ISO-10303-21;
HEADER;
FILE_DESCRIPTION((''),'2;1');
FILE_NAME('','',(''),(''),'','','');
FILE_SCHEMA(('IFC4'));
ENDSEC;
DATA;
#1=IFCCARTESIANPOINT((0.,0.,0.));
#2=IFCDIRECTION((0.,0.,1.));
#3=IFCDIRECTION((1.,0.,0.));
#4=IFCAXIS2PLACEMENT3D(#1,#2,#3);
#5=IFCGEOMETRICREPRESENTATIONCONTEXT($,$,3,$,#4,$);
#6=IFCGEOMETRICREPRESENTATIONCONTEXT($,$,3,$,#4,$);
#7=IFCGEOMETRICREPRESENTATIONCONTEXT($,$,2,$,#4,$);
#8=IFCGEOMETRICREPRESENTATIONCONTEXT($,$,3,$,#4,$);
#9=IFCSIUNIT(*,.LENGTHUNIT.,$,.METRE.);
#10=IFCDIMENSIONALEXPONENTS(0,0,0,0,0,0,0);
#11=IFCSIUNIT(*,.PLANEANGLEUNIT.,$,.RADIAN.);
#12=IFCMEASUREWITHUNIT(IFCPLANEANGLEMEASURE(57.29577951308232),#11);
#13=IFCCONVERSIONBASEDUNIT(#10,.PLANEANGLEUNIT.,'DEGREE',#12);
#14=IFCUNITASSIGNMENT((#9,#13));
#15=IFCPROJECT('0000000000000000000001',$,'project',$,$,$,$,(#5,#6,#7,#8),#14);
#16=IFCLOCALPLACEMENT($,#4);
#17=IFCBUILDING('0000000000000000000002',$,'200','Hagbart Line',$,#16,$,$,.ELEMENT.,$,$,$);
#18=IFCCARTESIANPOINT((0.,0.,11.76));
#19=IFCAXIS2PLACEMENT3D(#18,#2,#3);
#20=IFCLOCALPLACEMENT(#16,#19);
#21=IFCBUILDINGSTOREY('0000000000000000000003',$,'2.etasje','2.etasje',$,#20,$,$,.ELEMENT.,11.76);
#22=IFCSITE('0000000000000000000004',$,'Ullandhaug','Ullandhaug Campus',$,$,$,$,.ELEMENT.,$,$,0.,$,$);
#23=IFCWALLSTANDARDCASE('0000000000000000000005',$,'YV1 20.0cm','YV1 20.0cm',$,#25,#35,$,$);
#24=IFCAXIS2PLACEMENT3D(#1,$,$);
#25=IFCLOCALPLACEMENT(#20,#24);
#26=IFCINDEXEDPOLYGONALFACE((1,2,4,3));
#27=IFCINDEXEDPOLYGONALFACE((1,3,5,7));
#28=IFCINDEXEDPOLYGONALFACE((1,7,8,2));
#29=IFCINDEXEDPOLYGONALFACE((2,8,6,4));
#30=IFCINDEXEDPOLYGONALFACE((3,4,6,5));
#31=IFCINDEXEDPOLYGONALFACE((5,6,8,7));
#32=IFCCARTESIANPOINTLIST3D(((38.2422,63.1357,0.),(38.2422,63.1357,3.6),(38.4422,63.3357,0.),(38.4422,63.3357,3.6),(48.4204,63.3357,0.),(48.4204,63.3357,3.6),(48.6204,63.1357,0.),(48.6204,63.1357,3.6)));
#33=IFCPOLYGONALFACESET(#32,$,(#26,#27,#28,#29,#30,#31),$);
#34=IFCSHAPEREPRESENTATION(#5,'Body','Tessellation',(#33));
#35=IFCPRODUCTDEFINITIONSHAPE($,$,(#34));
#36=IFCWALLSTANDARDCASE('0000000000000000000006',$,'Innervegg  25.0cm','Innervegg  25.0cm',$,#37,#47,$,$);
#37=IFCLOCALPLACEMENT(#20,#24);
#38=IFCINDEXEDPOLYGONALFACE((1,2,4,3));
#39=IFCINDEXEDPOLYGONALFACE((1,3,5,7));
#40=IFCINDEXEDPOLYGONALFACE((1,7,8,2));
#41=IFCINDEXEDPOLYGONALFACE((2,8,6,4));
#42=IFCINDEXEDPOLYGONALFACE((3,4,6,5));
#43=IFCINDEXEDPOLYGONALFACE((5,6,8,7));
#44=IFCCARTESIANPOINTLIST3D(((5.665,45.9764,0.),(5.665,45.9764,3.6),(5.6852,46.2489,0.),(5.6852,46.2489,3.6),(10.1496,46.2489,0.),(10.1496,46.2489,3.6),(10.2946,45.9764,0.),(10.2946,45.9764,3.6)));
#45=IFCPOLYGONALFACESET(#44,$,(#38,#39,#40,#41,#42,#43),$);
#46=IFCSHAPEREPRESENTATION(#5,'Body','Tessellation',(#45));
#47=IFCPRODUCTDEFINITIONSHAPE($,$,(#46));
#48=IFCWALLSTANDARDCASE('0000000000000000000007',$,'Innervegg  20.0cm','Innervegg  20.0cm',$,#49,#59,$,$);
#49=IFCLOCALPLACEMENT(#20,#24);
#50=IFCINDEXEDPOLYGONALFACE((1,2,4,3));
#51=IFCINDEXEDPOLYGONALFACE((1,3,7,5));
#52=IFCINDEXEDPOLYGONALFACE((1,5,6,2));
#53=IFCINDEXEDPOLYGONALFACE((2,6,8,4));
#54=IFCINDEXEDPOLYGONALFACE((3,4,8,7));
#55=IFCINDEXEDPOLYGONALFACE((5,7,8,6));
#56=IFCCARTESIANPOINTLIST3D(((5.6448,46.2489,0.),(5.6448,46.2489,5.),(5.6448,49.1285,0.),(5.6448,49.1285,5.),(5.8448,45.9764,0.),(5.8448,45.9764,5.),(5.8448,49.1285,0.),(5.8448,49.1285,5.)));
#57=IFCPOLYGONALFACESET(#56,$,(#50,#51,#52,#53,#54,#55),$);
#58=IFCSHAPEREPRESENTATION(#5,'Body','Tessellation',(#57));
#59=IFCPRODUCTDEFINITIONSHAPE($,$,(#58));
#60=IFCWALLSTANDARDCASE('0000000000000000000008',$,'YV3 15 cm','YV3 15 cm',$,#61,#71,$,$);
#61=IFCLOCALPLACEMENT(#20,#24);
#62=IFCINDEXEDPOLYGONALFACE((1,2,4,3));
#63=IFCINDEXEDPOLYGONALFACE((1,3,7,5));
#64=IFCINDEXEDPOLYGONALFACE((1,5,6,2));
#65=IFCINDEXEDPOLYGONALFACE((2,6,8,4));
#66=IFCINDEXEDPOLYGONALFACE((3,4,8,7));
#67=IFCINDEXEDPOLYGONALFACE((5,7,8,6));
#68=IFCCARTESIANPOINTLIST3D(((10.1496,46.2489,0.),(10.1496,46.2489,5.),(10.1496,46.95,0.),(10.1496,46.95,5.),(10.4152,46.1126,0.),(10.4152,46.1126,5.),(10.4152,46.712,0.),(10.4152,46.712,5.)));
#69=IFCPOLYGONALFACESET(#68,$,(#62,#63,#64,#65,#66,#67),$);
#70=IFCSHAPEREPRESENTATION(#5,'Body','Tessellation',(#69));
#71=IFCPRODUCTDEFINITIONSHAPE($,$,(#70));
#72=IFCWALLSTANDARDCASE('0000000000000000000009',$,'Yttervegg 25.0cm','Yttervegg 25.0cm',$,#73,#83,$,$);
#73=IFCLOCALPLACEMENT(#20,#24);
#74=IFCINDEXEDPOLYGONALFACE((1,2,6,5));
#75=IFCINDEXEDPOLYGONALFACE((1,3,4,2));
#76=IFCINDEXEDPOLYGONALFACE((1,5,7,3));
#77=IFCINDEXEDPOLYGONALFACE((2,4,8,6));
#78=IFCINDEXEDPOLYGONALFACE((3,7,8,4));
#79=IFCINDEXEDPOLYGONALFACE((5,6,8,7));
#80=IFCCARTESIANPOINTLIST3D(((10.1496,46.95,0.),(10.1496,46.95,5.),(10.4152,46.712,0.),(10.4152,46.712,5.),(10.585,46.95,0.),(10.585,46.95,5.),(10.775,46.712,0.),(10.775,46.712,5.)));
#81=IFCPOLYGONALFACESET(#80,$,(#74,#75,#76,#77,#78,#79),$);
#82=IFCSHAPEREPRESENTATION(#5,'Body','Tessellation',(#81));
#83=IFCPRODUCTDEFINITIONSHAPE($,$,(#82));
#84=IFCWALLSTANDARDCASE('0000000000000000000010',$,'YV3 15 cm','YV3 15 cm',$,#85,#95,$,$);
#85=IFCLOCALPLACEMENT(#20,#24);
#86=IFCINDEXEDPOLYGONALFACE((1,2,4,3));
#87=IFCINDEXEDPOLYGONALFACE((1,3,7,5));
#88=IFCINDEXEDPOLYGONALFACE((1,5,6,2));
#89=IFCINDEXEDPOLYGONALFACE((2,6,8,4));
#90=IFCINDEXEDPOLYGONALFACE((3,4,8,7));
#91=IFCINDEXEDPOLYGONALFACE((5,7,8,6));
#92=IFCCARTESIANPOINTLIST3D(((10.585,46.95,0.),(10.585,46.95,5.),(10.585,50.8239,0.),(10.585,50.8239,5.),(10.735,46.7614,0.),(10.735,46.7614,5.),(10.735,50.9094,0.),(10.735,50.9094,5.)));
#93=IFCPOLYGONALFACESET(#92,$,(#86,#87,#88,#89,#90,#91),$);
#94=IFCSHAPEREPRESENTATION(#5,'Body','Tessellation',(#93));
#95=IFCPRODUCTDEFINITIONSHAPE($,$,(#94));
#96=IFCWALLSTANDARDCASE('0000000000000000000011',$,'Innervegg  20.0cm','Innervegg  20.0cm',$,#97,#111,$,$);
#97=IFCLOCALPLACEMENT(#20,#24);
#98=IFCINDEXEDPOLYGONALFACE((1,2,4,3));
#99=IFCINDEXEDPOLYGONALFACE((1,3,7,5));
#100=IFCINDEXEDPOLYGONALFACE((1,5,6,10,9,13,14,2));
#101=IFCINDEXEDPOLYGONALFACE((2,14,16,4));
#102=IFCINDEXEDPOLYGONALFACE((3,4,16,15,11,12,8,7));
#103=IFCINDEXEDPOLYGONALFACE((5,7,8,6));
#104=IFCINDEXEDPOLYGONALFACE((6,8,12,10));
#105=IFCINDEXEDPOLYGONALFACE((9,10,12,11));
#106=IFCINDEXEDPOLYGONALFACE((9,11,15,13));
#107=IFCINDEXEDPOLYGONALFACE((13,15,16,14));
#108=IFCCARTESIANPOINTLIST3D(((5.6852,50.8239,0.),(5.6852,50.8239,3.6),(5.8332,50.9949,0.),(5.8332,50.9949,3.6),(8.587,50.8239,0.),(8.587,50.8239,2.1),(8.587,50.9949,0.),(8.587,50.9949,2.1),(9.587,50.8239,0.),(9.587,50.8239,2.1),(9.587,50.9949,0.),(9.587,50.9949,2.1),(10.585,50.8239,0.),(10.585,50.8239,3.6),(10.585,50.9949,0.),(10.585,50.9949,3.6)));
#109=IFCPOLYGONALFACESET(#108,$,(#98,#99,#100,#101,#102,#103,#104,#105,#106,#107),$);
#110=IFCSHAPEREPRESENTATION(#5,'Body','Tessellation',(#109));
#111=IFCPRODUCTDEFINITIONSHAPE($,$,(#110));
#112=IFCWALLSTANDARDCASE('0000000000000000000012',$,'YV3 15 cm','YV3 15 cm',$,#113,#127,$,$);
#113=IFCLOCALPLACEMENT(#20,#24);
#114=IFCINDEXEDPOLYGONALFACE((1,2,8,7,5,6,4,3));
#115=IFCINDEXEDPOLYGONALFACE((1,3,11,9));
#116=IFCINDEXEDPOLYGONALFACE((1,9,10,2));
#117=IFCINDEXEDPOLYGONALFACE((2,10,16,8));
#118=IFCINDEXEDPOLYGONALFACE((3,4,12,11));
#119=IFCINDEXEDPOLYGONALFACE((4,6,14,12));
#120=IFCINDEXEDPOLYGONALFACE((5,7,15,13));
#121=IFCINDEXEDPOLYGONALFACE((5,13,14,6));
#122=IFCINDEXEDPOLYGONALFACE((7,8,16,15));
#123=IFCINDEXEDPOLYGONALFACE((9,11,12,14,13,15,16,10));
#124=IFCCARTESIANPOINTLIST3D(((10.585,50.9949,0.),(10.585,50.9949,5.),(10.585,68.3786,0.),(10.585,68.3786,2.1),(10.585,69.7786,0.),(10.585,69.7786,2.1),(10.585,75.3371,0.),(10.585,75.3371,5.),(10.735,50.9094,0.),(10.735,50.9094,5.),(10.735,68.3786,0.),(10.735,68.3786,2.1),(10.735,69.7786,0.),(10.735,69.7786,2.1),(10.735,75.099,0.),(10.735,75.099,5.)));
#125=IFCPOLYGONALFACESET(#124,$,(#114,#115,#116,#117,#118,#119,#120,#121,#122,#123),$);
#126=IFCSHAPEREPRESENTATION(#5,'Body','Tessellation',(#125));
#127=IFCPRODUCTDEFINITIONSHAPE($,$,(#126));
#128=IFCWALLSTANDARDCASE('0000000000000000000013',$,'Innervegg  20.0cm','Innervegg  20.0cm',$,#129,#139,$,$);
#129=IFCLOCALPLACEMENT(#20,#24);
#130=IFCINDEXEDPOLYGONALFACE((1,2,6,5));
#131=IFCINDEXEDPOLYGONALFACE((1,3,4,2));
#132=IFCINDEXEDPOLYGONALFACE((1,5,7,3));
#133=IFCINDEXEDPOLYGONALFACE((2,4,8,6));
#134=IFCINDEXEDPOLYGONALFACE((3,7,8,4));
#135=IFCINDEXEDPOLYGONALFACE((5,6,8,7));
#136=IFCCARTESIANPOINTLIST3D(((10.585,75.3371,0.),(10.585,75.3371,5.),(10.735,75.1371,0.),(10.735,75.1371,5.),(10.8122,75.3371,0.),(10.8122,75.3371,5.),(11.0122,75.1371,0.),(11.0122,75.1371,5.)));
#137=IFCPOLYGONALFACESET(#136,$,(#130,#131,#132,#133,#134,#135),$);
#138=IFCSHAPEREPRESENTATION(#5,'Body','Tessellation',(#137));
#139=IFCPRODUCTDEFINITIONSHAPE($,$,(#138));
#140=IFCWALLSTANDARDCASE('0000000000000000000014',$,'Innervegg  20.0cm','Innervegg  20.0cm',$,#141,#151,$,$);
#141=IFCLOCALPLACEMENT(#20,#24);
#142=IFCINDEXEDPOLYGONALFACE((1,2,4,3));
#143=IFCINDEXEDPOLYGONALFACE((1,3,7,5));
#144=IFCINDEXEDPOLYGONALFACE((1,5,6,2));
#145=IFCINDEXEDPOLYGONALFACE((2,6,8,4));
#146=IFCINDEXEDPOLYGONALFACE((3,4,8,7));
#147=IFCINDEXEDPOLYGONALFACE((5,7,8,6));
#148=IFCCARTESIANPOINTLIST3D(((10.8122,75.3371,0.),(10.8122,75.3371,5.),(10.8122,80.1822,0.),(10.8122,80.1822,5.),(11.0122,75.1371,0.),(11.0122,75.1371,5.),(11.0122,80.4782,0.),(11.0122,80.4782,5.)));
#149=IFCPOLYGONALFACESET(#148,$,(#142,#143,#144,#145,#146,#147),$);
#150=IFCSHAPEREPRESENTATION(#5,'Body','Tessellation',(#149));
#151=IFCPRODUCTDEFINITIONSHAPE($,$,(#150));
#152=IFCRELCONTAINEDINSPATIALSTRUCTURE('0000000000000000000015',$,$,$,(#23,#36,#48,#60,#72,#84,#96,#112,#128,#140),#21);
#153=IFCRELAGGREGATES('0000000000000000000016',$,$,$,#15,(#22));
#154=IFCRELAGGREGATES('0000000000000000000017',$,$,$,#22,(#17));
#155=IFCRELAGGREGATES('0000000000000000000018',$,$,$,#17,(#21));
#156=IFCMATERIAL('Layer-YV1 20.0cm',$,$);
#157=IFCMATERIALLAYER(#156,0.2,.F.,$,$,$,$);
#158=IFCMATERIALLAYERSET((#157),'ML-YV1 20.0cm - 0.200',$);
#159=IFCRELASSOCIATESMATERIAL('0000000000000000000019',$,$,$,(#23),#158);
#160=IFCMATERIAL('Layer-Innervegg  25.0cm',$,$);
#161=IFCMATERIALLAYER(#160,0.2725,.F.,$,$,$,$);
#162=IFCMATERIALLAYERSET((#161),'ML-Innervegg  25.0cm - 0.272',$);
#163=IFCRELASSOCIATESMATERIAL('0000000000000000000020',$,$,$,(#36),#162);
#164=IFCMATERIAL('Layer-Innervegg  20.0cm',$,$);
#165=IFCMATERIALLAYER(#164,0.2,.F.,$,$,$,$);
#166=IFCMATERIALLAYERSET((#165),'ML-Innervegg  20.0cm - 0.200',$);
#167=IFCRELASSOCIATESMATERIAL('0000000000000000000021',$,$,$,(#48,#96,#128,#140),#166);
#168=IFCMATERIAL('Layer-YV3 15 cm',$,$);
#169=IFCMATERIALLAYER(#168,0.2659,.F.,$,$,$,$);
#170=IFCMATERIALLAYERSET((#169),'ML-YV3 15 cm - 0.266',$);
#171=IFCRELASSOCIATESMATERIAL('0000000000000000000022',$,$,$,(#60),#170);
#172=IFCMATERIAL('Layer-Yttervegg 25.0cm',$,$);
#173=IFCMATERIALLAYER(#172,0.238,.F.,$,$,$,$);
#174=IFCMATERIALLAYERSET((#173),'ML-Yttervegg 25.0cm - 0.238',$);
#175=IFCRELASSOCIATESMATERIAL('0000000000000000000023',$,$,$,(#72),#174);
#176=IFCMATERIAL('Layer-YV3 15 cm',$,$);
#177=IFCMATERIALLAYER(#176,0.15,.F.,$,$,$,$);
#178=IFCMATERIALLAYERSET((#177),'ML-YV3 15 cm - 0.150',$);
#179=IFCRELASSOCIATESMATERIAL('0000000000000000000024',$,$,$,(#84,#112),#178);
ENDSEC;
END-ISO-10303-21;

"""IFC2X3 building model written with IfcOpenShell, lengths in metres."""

from ifc_helpers import new_model, entity, si_unit, converted_unit, frame, origin_with_axes, place, context, project, spatial, polyline, outline, extrude, material, layer, layer_set, layer_usage, element, save


model = new_model("IFC2X3")

# Units and contexts
context_of_model_1 = context(None, 3, world=origin_with_axes())
context_of_model_2 = context(None, 3, world=origin_with_axes())
context_of_model_3 = context(None, 2, world=origin_with_axes())
context_of_model_4 = context(None, 3, world=origin_with_axes())
ifc_project = project(units=[si_unit("LENGTHUNIT", "METRE"), converted_unit("PLANEANGLEUNIT", "DEGREE", entity("IfcPlaneAngleMeasure", 57.29577951308232), si_unit("PLANEANGLEUNIT", "RADIAN"), dimensions=[0, 0, 0, 0, 0, 0, 0])], contexts=[context_of_model_1, context_of_model_2, context_of_model_3, context_of_model_4])

# Site, building, storey
site = spatial("IfcSite", under=ifc_project, Name="Ullandhaug", Description="Ullandhaug Campus", CompositionType="ELEMENT", RefElevation=0.0)
building_placement = place(None, origin_with_axes())
building = spatial("IfcBuilding", under=site, at=building_placement, Name="200", Description="Hagbart Line", CompositionType="ELEMENT")
storey_placement = place(building_placement, frame((0.0, 0.0, 11.76), z_axis=(0.0, 0.0, 1.0), x_axis=(1.0, 0.0, 0.0)))
storey = spatial("IfcBuildingStorey", under=building, at=storey_placement, Name="2.etasje", Description="2.etasje", CompositionType="ELEMENT", Elevation=11.76)

# Walls
ifc_material_1 = material(Name="Layer-YV3 15 cm")
ifc_layer_1 = layer(ifc_material_1, 0.15, ventilated=False)
ifc_layer_set_1 = layer_set([ifc_layer_1], Name="ML-YV3 15 cm - 0.150")
ifc_layer_usage_1 = layer_usage(ifc_layer_set_1, "AXIS2", "POSITIVE", 0.0)
ifc_material_2 = material(Name="Layer-YV1 20.0cm")
ifc_layer_2 = layer(ifc_material_2, 0.2, ventilated=False)
ifc_layer_set_2 = layer_set([ifc_layer_2], Name="ML-YV1 20.0cm - 0.200")
ifc_layer_usage_2 = layer_usage(ifc_layer_set_2, "AXIS2", "POSITIVE", 0.0)
wall_1_placement = place(storey_placement, frame((48.4204, 63.3357, 0.0), z_axis=(0.0, 0.0, 1.0), x_axis=(-1.0, 0.0, 0.0)))
element("IfcWallStandardCase", 1, at=wall_1_placement, inside=storey, material=ifc_layer_usage_2, Name="YV1 20.0cm", Description="YV1 20.0cm", context=context_of_model_1, shape_type="SweptSolid", body=[
    extrude(outline(polyline([(0.0, 0.0), (9.9782, 0.0), (10.1782, 0.2), (-0.2, 0.2), (0.0, 0.0)])), frame((0.0, 0.0, 0.0), z_axis=(0.0, 0.0, 1.0), x_axis=(1.0, 0.0, 0.0)), (0.0, 0.0, 1.0), 3.6),
])
ifc_material_3 = material(Name="Layer-Innervegg  25.0cm")
ifc_layer_3 = layer(ifc_material_3, 0.2725, ventilated=False)
ifc_layer_set_3 = layer_set([ifc_layer_3], Name="ML-Innervegg  25.0cm - 0.272")
ifc_layer_usage_3 = layer_usage(ifc_layer_set_3, "AXIS2", "POSITIVE", 0.0)
wall_2_placement = place(storey_placement, frame((10.1496, 46.2489, 0.0), z_axis=(0.0, 0.0, 1.0), x_axis=(-1.0, 0.0, 0.0)))
element("IfcWallStandardCase", 2, at=wall_2_placement, inside=storey, material=ifc_layer_usage_3, Name="Innervegg  25.0cm", Description="Innervegg  25.0cm", context=context_of_model_1, shape_type="SweptSolid", body=[
    extrude(outline(polyline([(0.0, 0.0), (4.4644, 0.0), (4.4846, 0.2725), (-0.145, 0.2725), (0.0, 0.0)])), frame((0.0, 0.0, 0.0), z_axis=(0.0, 0.0, 1.0), x_axis=(1.0, 0.0, 0.0)), (0.0, 0.0, 1.0), 3.6),
])
ifc_material_4 = material(Name="Layer-Innervegg  20.0cm")
ifc_layer_4 = layer(ifc_material_4, 0.2, ventilated=False)
ifc_layer_set_4 = layer_set([ifc_layer_4], Name="ML-Innervegg  20.0cm - 0.200")
ifc_layer_usage_4 = layer_usage(ifc_layer_set_4, "AXIS2", "POSITIVE", 0.0)
wall_3_placement = place(storey_placement, frame((5.8448, 45.9764, 0.0), z_axis=(0.0, 0.0, 1.0), x_axis=(0.0, 1.0, 0.0)))
element("IfcWallStandardCase", 3, at=wall_3_placement, inside=storey, material=ifc_layer_usage_4, Name="Innervegg  20.0cm", Description="Innervegg  20.0cm", context=context_of_model_1, shape_type="SweptSolid", body=[
    extrude(outline(polyline([(0.0, 0.0), (3.1521, 0.0), (3.1521, 0.2), (0.2725, 0.2), (0.0, 0.0)])), frame((0.0, 0.0, 0.0), z_axis=(0.0, 0.0, 1.0), x_axis=(1.0, 0.0, 0.0)), (0.0, 0.0, 1.0), 5.0),
])
ifc_material_5 = material(Name="Layer-YV3 15 cm")
ifc_layer_5 = layer(ifc_material_5, 0.2659, ventilated=False)
ifc_layer_set_5 = layer_set([ifc_layer_5], Name="ML-YV3 15 cm - 0.266")
ifc_layer_usage_5 = layer_usage(ifc_layer_set_5, "AXIS2", "POSITIVE", 0.0)
wall_4_placement = place(storey_placement, frame((10.4152, 46.1126, 0.0), z_axis=(0.0, 0.0, 1.0), x_axis=(0.0, 1.0, 0.0)))
element("IfcWallStandardCase", 4, at=wall_4_placement, inside=storey, material=ifc_layer_usage_5, Name="YV3 15 cm", Description="YV3 15 cm", context=context_of_model_1, shape_type="SweptSolid", body=[
    extrude(outline(polyline([(0.0, 0.0), (0.5993, 0.0), (0.8373, 0.2656), (0.1362, 0.2656), (0.0, 0.0)])), frame((0.0, 0.0, 0.0), z_axis=(0.0, 0.0, 1.0), x_axis=(1.0, 0.0, 0.0)), (0.0, 0.0, 1.0), 5.0),
])
ifc_material_6 = material(Name="Layer-Yttervegg 25.0cm")
ifc_layer_6 = layer(ifc_material_6, 0.238, ventilated=False)
ifc_layer_set_6 = layer_set([ifc_layer_6], Name="ML-Yttervegg 25.0cm - 0.238")
ifc_layer_usage_6 = layer_usage(ifc_layer_set_6, "AXIS2", "POSITIVE", 0.0)
wall_5_placement = place(storey_placement, frame((10.4152, 46.712, 0.0), z_axis=(0.0, 0.0, 1.0), x_axis=(1.0, 0.0, 0.0)))
element("IfcWallStandardCase", 5, at=wall_5_placement, inside=storey, material=ifc_layer_usage_6, Name="Yttervegg 25.0cm", Description="Yttervegg 25.0cm", context=context_of_model_1, shape_type="SweptSolid", body=[
    extrude(outline(polyline([(0.0, 0.0), (0.3598, 0.0), (0.1698, 0.238), (-0.2656, 0.238), (0.0, 0.0)])), origin_with_axes(), (0.0, 0.0, 1.0), 5.0),
])
wall_6_placement = place(storey_placement, frame((10.735, 46.7614, 0.0), z_axis=(0.0, 0.0, 1.0), x_axis=(0.0, 1.0, 0.0)))
element("IfcWallStandardCase", 6, at=wall_6_placement, inside=storey, material=ifc_layer_usage_1, Name="YV3 15 cm", Description="YV3 15 cm", context=context_of_model_1, shape_type="SweptSolid", body=[
    extrude(outline(polyline([(0.0, 0.0), (4.148, 0.0), (4.0625, 0.15), (0.1885, 0.15), (0.0, 0.0)])), frame((0.0, 0.0, 0.0), z_axis=(0.0, 0.0, 1.0), x_axis=(1.0, 0.0, 0.0)), (0.0, 0.0, 1.0), 5.0),
])

# Wall, opening
wall_7_placement = place(storey_placement, frame((10.585, 50.9949, 0.0), z_axis=(0.0, 0.0, 1.0), x_axis=(-1.0, 0.0, 0.0)))
wall_7 = element("IfcWallStandardCase", 7, at=wall_7_placement, inside=storey, material=ifc_layer_usage_4, Name="Innervegg  20.0cm", Description="Innervegg  20.0cm", context=context_of_model_1, shape_type="SweptSolid", body=[
    extrude(outline(polyline([(0.0, 0.0), (4.7518, 0.0), (4.8998, 0.171), (0.0, 0.171), (0.0, 0.0)])), frame((0.0, 0.0, 0.0), z_axis=(0.0, 0.0, 1.0), x_axis=(1.0, 0.0, 0.0)), (0.0, 0.0, 1.0), 3.6),
])
opening_1_placement = place(wall_7_placement, frame((0.998, 0.171, 0.0), z_axis=(0.0, 0.0, 1.0), x_axis=(1.0, 0.0, 0.0)))
element("IfcOpeningElement", 8, at=opening_1_placement, cuts=wall_7, context=context_of_model_1, shape_type="SweptSolid", body=[
    extrude(outline(polyline([(0.0, 0.0), (2.1, 0.0), (2.1, 1.0), (0.0, 1.0), (0.0, 0.0)])), frame((0.0, 0.0, 0.0), z_axis=(0.0, 1.0, 0.0), x_axis=(0.0, 0.0, 1.0)), (0.0, 0.0, -1.0), 0.2),
])

# Wall, opening
wall_8_placement = place(storey_placement, frame((10.735, 50.9094, 0.0), z_axis=(0.0, 0.0, 1.0), x_axis=(0.0, 1.0, 0.0)))
wall_8 = element("IfcWallStandardCase", 9, at=wall_8_placement, inside=storey, material=ifc_layer_usage_1, Name="YV3 15 cm", Description="YV3 15 cm", context=context_of_model_1, shape_type="SweptSolid", body=[
    extrude(outline(polyline([(0.0, 0.0), (24.1897, 0.0), (24.4277, 0.15), (0.0855, 0.15), (0.0, 0.0)])), frame((0.0, 0.0, 0.0), z_axis=(0.0, 0.0, 1.0), x_axis=(1.0, 0.0, 0.0)), (0.0, 0.0, 1.0), 5.0),
])
opening_2_placement = place(wall_8_placement, frame((17.4692, 0.15, 0.0), z_axis=(0.0, 0.0, 1.0), x_axis=(1.0, 0.0, 0.0)))
element("IfcOpeningElement", 10, at=opening_2_placement, cuts=wall_8, context=context_of_model_1, shape_type="SweptSolid", body=[
    extrude(outline(polyline([(0.0, 0.0), (2.1, 0.0), (2.1, 1.4), (0.0, 1.4), (0.0, 0.0)])), frame((0.0, 0.0, 0.0), z_axis=(0.0, 1.0, 0.0), x_axis=(0.0, 0.0, 1.0)), (0.0, 0.0, -1.0), 0.15),
])

# Walls
wall_9_placement = place(storey_placement, frame((10.735, 75.1371, 0.0), z_axis=(0.0, 0.0, 1.0), x_axis=(1.0, 0.0, 0.0)))
element("IfcWallStandardCase", 11, at=wall_9_placement, inside=storey, material=ifc_layer_usage_4, Name="Innervegg  20.0cm", Description="Innervegg  20.0cm", context=context_of_model_1, shape_type="SweptSolid", body=[
    extrude(outline(polyline([(0.0, 0.0), (0.2772, 0.0), (0.0772, 0.2), (-0.15, 0.2), (0.0, 0.0)])), origin_with_axes(), (0.0, 0.0, 1.0), 5.0),
])
wall_10_placement = place(storey_placement, frame((11.0122, 75.1371, 0.0), z_axis=(0.0, 0.0, 1.0), x_axis=(0.0, 1.0, 0.0)))
element("IfcWallStandardCase", 12, at=wall_10_placement, inside=storey, material=ifc_layer_usage_4, Name="Innervegg  20.0cm", Description="Innervegg  20.0cm", context=context_of_model_1, shape_type="SweptSolid", body=[
    extrude(outline(polyline([(0.0, 0.0), (5.3411, 0.0), (5.0451, 0.2), (0.2, 0.2), (0.0, 0.0)])), frame((0.0, 0.0, 0.0), z_axis=(0.0, 0.0, 1.0), x_axis=(1.0, 0.0, 0.0)), (0.0, 0.0, 1.0), 5.0),
])

save(model, "model.ifc")
